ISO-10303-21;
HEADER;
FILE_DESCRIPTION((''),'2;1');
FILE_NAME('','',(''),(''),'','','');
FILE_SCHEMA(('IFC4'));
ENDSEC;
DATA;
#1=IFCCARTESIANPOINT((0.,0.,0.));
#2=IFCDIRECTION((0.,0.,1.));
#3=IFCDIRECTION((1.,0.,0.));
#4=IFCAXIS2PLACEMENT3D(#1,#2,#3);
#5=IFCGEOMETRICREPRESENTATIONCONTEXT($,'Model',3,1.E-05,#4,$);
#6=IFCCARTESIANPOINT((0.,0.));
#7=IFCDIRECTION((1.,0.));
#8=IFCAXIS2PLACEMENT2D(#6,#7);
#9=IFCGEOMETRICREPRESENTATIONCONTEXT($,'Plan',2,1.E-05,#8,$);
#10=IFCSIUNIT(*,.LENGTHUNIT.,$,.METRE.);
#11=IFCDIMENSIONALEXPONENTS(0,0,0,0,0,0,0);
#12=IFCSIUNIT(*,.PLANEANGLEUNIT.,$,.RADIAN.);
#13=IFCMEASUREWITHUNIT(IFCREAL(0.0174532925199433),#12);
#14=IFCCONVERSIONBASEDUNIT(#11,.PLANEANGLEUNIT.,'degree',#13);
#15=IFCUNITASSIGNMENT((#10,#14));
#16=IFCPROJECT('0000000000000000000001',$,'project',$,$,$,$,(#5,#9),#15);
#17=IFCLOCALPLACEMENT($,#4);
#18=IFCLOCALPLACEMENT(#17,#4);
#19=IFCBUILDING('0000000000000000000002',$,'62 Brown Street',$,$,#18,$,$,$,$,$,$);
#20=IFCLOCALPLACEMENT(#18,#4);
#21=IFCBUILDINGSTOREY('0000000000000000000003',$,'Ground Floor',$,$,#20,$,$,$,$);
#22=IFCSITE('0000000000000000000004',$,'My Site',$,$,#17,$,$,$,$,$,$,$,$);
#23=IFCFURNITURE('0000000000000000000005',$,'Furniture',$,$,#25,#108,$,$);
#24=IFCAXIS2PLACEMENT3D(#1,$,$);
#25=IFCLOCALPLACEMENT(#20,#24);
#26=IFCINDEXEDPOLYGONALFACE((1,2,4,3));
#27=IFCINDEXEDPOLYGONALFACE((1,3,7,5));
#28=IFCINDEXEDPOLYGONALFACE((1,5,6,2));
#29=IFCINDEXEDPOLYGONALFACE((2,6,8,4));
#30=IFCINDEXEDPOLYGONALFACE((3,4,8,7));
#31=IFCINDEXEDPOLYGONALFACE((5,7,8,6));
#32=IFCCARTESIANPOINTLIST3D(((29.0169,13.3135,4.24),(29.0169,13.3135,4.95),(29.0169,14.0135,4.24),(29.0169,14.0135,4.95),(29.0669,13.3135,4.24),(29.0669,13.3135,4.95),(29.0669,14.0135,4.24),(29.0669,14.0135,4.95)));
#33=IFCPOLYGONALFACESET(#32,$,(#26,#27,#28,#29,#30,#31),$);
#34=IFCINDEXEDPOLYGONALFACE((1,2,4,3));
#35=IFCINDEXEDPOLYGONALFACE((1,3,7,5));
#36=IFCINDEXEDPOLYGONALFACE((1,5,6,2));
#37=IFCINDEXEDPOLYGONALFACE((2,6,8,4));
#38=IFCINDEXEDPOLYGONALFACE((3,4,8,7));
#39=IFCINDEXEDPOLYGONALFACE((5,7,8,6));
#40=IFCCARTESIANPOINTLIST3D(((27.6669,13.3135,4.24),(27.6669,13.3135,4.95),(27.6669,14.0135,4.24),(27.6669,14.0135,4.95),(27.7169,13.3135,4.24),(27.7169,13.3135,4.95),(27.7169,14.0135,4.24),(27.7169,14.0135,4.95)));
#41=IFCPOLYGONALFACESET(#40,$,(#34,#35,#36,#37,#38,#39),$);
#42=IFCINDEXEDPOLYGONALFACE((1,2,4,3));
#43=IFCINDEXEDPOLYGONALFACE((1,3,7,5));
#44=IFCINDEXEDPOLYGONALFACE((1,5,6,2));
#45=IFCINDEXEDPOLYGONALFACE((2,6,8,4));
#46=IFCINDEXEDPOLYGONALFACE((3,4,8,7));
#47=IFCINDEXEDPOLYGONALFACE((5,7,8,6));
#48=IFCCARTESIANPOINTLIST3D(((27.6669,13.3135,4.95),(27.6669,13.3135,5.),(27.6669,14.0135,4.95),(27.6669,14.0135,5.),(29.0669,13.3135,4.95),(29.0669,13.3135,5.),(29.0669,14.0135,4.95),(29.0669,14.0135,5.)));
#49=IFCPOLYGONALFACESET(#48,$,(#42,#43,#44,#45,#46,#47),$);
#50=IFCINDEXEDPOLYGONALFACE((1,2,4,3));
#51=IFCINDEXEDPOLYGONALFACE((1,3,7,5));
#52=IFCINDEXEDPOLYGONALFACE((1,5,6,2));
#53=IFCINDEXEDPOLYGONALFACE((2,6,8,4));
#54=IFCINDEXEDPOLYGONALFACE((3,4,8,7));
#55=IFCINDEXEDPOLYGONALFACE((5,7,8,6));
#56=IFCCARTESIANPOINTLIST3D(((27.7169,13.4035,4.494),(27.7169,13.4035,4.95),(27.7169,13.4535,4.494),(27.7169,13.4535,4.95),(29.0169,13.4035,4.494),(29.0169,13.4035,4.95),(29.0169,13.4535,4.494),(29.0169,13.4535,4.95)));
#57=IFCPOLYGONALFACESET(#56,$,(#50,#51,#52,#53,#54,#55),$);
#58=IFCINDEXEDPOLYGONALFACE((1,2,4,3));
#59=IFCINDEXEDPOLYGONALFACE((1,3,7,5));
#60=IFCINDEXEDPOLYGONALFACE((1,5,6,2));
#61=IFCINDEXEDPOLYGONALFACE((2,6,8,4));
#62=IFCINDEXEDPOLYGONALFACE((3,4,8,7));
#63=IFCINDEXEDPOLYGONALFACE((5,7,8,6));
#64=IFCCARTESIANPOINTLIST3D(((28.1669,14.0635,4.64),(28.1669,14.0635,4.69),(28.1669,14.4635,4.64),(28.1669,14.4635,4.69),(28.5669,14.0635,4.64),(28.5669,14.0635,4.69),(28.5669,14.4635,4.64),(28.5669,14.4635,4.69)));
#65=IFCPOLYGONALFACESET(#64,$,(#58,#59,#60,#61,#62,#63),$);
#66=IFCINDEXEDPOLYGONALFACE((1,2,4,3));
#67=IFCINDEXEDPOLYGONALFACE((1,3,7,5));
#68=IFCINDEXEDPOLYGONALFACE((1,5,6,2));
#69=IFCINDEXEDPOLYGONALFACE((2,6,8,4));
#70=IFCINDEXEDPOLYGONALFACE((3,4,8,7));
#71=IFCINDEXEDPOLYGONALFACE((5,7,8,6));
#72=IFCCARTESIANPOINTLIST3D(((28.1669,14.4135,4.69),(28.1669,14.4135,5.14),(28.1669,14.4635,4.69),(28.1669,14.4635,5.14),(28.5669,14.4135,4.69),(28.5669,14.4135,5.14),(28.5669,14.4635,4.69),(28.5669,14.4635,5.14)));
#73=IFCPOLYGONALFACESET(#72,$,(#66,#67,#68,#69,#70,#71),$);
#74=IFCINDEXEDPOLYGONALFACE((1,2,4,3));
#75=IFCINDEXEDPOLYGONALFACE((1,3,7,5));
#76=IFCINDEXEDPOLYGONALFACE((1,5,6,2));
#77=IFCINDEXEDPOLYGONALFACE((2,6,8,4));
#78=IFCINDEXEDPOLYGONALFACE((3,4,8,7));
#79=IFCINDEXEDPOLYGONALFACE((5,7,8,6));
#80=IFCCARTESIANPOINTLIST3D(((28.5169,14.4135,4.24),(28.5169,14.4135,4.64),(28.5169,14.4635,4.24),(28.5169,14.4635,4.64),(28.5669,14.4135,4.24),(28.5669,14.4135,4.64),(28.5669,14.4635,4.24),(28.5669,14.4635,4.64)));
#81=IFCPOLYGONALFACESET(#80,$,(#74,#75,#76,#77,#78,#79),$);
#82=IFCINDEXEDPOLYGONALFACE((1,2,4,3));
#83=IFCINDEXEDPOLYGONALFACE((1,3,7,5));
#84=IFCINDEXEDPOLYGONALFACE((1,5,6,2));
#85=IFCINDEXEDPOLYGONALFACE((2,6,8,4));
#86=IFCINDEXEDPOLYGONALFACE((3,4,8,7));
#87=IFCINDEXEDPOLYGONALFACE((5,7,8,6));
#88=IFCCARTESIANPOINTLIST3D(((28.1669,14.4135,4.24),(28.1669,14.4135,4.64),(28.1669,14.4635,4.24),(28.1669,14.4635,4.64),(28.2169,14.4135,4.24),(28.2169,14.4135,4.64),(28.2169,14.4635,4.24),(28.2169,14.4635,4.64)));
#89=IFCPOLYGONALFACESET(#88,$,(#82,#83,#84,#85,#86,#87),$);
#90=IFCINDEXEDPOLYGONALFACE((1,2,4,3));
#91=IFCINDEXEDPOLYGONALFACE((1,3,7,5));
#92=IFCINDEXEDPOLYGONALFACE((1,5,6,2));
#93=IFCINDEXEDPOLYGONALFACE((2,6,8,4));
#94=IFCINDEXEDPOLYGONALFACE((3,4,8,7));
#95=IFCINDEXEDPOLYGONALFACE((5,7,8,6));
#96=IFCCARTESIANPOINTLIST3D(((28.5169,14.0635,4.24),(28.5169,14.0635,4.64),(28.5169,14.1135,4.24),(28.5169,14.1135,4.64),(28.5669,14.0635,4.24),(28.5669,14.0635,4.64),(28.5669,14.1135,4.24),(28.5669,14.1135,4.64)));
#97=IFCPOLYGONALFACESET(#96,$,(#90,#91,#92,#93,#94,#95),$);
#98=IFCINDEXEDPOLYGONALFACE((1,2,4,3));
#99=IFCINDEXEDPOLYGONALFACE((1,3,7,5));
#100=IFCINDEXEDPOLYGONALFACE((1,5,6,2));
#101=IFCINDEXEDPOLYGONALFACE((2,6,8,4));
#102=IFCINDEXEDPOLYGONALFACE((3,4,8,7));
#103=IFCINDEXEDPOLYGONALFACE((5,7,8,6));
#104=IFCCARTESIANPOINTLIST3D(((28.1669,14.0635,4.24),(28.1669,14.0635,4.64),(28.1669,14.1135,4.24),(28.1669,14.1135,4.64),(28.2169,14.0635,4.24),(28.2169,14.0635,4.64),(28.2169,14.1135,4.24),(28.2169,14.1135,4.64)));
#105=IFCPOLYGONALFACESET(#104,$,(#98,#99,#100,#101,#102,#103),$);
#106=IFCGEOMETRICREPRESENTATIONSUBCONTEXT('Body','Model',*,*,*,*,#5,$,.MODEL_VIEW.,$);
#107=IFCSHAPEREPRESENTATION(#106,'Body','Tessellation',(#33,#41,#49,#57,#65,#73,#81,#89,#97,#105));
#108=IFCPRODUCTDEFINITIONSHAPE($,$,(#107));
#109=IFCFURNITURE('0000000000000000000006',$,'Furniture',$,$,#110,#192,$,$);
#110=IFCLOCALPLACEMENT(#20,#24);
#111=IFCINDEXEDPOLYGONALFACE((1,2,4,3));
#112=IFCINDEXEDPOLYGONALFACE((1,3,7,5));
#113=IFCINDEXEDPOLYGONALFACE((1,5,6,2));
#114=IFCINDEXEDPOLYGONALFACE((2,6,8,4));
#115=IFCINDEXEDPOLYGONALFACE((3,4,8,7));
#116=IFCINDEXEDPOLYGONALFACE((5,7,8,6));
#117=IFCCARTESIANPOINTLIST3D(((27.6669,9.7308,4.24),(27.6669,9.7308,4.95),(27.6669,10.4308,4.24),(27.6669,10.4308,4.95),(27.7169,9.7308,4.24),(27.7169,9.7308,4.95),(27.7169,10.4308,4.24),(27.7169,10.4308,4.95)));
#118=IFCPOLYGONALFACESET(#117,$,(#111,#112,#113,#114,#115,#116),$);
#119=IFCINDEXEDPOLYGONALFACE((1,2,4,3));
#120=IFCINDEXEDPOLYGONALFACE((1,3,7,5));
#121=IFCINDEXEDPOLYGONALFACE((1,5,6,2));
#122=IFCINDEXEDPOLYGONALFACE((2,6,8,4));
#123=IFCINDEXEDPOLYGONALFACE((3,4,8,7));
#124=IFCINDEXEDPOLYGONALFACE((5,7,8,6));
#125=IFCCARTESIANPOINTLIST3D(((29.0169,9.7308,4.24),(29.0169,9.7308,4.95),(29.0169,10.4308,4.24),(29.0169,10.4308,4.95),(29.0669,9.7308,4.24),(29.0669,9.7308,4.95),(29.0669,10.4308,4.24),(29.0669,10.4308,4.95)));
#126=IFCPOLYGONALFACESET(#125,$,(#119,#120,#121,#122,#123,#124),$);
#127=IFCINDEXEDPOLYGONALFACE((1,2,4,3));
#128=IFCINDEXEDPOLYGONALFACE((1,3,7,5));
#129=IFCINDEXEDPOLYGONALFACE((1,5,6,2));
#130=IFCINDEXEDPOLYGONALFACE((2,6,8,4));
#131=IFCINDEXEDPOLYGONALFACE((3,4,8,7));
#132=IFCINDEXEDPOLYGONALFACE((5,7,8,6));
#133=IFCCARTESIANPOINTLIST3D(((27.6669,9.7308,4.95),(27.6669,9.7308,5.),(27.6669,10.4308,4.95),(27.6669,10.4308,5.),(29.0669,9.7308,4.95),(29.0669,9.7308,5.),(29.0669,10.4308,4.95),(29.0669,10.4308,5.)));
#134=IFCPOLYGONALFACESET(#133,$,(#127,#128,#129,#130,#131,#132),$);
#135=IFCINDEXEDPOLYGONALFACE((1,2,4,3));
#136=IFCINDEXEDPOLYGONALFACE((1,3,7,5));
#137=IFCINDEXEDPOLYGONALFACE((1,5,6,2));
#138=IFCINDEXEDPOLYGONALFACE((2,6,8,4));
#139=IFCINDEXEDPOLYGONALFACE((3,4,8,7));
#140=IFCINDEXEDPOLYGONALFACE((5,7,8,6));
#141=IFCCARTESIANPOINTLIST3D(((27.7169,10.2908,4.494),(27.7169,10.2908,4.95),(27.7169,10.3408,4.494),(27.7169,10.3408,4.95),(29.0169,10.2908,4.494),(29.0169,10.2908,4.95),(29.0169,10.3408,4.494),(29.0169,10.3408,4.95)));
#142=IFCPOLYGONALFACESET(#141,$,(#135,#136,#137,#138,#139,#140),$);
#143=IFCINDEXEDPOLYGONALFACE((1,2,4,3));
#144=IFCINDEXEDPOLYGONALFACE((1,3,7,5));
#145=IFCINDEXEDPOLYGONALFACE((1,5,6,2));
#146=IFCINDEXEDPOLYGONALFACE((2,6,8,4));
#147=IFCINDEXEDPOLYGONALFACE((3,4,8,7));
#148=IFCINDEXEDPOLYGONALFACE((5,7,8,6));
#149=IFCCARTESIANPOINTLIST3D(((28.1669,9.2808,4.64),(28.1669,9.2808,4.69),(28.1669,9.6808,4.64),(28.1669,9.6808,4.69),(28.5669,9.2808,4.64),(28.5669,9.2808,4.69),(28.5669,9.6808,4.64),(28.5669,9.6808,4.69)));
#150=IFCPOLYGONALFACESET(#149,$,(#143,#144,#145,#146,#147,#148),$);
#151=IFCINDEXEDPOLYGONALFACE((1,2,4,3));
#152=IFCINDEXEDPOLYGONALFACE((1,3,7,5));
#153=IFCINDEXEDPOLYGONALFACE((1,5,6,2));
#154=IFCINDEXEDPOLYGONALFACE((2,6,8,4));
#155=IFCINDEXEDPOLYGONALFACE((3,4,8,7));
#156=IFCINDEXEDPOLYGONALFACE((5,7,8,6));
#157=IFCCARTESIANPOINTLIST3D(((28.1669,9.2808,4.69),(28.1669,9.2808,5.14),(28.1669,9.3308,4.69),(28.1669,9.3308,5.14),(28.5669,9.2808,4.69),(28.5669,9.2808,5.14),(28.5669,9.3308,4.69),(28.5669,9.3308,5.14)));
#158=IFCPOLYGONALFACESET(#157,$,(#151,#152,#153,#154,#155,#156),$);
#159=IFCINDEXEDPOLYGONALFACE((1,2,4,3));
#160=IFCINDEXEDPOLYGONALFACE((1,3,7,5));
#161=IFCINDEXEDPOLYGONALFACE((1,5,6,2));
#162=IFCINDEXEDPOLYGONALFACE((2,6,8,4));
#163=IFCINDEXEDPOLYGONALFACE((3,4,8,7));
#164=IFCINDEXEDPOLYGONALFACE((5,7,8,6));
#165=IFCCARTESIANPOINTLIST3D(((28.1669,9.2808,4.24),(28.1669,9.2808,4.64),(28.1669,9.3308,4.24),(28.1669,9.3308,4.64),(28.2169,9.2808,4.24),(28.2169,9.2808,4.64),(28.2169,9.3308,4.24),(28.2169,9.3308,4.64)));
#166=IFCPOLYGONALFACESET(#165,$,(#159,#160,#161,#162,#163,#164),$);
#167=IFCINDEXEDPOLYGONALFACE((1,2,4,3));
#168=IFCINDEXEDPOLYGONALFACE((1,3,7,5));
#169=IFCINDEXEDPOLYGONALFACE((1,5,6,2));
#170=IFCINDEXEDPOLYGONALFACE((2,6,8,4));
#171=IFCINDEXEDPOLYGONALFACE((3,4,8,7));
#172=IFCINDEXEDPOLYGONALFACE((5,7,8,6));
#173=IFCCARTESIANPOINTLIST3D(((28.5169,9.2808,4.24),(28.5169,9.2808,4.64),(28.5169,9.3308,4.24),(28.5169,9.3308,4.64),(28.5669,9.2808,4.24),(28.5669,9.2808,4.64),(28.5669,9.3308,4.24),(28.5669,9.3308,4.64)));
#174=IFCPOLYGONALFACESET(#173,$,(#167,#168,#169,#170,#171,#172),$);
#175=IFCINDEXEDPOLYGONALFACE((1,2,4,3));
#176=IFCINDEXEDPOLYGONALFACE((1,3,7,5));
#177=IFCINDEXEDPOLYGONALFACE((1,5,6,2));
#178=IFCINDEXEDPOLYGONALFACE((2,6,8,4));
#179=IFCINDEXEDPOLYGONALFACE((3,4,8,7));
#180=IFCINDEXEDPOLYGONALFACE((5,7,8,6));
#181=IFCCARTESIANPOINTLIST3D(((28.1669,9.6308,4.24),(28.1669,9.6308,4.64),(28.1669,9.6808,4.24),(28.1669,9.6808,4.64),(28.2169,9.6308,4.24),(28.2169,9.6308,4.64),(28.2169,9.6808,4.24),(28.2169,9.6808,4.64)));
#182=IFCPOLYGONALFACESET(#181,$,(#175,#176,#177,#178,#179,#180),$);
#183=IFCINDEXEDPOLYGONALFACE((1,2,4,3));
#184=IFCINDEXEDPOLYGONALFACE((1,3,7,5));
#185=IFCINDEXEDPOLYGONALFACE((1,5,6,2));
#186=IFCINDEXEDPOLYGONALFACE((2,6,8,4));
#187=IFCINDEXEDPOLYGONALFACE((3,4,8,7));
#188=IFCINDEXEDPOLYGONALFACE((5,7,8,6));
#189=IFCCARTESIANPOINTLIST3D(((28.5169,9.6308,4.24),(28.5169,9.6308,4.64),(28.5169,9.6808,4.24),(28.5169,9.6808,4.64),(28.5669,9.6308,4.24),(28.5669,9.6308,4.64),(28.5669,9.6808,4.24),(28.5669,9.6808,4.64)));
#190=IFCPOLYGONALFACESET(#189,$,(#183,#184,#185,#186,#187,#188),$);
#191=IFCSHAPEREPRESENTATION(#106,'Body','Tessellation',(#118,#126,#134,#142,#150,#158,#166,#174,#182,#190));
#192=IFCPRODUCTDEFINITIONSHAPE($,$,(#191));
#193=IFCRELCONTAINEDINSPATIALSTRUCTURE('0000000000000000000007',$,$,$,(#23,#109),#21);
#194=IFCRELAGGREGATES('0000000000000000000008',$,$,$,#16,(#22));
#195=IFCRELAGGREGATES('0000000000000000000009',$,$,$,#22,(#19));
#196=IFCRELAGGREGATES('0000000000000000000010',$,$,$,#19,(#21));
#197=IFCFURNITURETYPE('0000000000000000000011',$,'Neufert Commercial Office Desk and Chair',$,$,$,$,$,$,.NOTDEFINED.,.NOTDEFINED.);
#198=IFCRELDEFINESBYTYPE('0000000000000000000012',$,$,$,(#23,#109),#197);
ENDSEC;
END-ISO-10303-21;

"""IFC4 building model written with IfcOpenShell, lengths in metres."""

from ifc_helpers import new_model, entity, si_unit, converted_unit, frame, origin_with_axes, origin_2d_with_axis, place, context, subcontext, project, spatial, line, indexed_curve, outline, extrude, shape, source, transform, mapped, type_object, type_shapes, element, save


model = new_model("IFC4")

# Units and contexts
model_context = context("Model", 3, precision=1e-05, world=origin_with_axes())
plan_context = context("Plan", 2, precision=1e-05, world=origin_2d_with_axis())
body_context_1 = subcontext(model_context, "Body", "Model", "MODEL_VIEW")
body_context_2 = subcontext(plan_context, "Body", "Plan", "PLAN_VIEW")
ifc_project = project(units=[si_unit("LENGTHUNIT", "METRE"), converted_unit("PLANEANGLEUNIT", "degree", entity("IfcReal", 0.0174532925199433), si_unit("PLANEANGLEUNIT", "RADIAN"), dimensions=[0, 0, 0, 0, 0, 0, 0])], contexts=[model_context, plan_context])

# Site, building, storey
site_placement = place(None, origin_with_axes())
site = spatial("IfcSite", under=ifc_project, at=site_placement, Name="My Site")
building_placement = place(site_placement, origin_with_axes())
building = spatial("IfcBuilding", under=site, at=building_placement, Name="62 Brown Street")
storey_placement = place(building_placement, origin_with_axes())
storey = spatial("IfcBuildingStorey", under=building, at=storey_placement, Name="Ground Floor")

# Furniture
furniture_type_1 = type_object("IfcFurnitureType", Name="Neufert Commercial Office Desk and Chair", AssemblyPlace="NOTDEFINED", PredefinedType="NOTDEFINED")
shared_shape_1 = source(origin_with_axes(), body_context_1, "Body", "SweptSolid", [
    extrude(outline(indexed_curve([(0.0, 0.0), (0.05, 0.0), (0.05, 0.7), (0.0, 0.7)], segments=[line(1, 2, 3, 4, 1)])), frame((0.0, 0.45, 0.0), z_axis=(0.0, 0.0, 1.0), x_axis=(1.0, 0.0, 0.0)), (0.0, 0.0, 1.0), 0.71),
    extrude(outline(indexed_curve([(0.0, 0.0), (0.05, 0.0), (0.05, 0.7), (0.0, 0.7)], segments=[line(1, 2, 3, 4, 1)])), frame((1.35, 0.45, 0.0), z_axis=(0.0, 0.0, 1.0), x_axis=(1.0, 0.0, 0.0)), (0.0, 0.0, 1.0), 0.71),
    extrude(outline(indexed_curve([(0.0, 0.0), (1.4, 0.0), (1.4, 0.7), (0.0, 0.7)], segments=[line(1, 2, 3, 4, 1)])), frame((0.0, 0.45, 0.71), z_axis=(0.0, 0.0, 1.0), x_axis=(1.0, 0.0, 0.0)), (0.0, 0.0, 1.0), 0.05),
    extrude(outline(indexed_curve([(0.05, 0.56), (1.35, 0.56), (1.35, 0.61), (0.05, 0.61)], segments=[line(1, 2, 3, 4, 1)])), frame((0.0, 0.45, 0.254), z_axis=(0.0, 0.0, 1.0), x_axis=(1.0, 0.0, 0.0)), (0.0, 0.0, 1.0), 0.456),
    extrude(outline(indexed_curve([(-0.2, 0.0), (0.2, 0.0), (0.2, 0.4), (-0.2, 0.4)], segments=[line(1, 2, 3, 4, 1)])), frame((0.7, 0.0, 0.45), z_axis=(0.0, 0.0, 1.0), x_axis=(1.0, 0.0, 0.0)), (0.0, 0.0, -1.0), 0.05),
    extrude(outline(indexed_curve([(-0.2, 0.0), (0.2, 0.0), (0.2, 0.05), (-0.2, 0.05)], segments=[line(1, 2, 3, 4, 1)])), frame((0.7, 0.0, 0.9), z_axis=(0.0, 0.0, 1.0), x_axis=(1.0, 0.0, 0.0)), (0.0, 0.0, -1.0), 0.45),
    extrude(outline(indexed_curve([(-0.2, 0.0), (-0.15, 0.0), (-0.15, 0.05), (-0.2, 0.05)], segments=[line(1, 2, 3, 4, 1)])), frame((0.7, 0.0, 0.0), z_axis=(0.0, 0.0, 1.0), x_axis=(1.0, 0.0, 0.0)), (0.0, 0.0, 1.0), 0.4),
    extrude(outline(indexed_curve([(0.2, 0.0), (0.15, 0.0), (0.15, 0.05), (0.2, 0.05)], segments=[line(1, 2, 3, 4, 1)])), frame((0.7, 0.0, 0.0), z_axis=(0.0, 0.0, 1.0), x_axis=(1.0, 0.0, 0.0)), (0.0, 0.0, 1.0), 0.4),
    extrude(outline(indexed_curve([(-0.2, 0.4), (-0.15, 0.4), (-0.15, 0.35), (-0.2, 0.35)], segments=[line(1, 2, 3, 4, 1)])), frame((0.7, 0.0, 0.0), z_axis=(0.0, 0.0, 1.0), x_axis=(1.0, 0.0, 0.0)), (0.0, 0.0, 1.0), 0.4),
    extrude(outline(indexed_curve([(0.2, 0.4), (0.15, 0.4), (0.15, 0.35), (0.2, 0.35)], segments=[line(1, 2, 3, 4, 1)])), frame((0.7, 0.0, 0.0), z_axis=(0.0, 0.0, 1.0), x_axis=(1.0, 0.0, 0.0)), (0.0, 0.0, 1.0), 0.4),
])
shared_shape_2 = source(origin_with_axes(), body_context_2, "Body", "Curve2D", [
    entity("IfcIndexedPolyCurve", entity("IfcCartesianPointList2D", [[0.0, 0.45], [1.4, 0.45], [1.4, 1.15], [0.0, 1.15]]), [entity("IfcLineIndex", [1, 2, 3, 4, 1])]),
    entity("IfcIndexedPolyCurve", entity("IfcCartesianPointList2D", [[0.5, 0.4], [0.9, 0.4]])),
    entity("IfcIndexedPolyCurve", entity("IfcCartesianPointList2D", [[0.5, 0.4], [0.5, 0.2], [0.5586, 0.0586], [0.7, 0.0], [0.8414, 0.0586], [0.9, 0.2], [0.9, 0.4]]), [entity("IfcLineIndex", [1, 2]), entity("IfcArcIndex", [2, 3, 4]), entity("IfcArcIndex", [4, 5, 6]), entity("IfcLineIndex", [6, 7])]),
    entity("IfcIndexedPolyCurve", entity("IfcCartesianPointList2D", [[0.54, 0.4], [0.54, 0.2], [0.5869, 0.0869], [0.7, 0.04], [0.8131, 0.0869], [0.86, 0.2], [0.86, 0.4]]), [entity("IfcLineIndex", [1, 2]), entity("IfcArcIndex", [2, 3, 4]), entity("IfcArcIndex", [4, 5, 6]), entity("IfcLineIndex", [6, 7])]),
])
type_shapes(furniture_type_1, [shared_shape_1, shared_shape_2])
for number, where, z_axis, x_axis, name in (
    (1, (29.0669, 14.4635, 4.24), (0.0, 0.0, 1.0), (-1.0, 0.0, 0.0), "Furniture"),
    (2, (27.6669, 9.2808, 4.24), (0.0, 0.0, 1.0), (1.0, 0.0, 0.0), "Furniture"),
):
    element("IfcFurniture", number, at=place(storey_placement, frame(where, z_axis=z_axis, x_axis=x_axis)), inside=storey, type_object=furniture_type_1, Name=name, shapes=[
        shape(body_context_1, "Body", "MappedRepresentation", [mapped(shared_shape_1, transform((0.0, 0.0, 0.0), x_axis=(1.0, 0.0, 0.0), y_axis=(0.0, 1.0, 0.0), z_axis=(0.0, 0.0, 1.0), scale=1.0))]),
        shape(body_context_2, "Body", "MappedRepresentation", [mapped(shared_shape_2, transform((0.0, 0.0, 0.0), x_axis=(1.0, 0.0, 0.0), y_axis=(0.0, 1.0, 0.0), z_axis=(0.0, 0.0, 1.0), scale=1.0))]),
    ])

save(model, "model.ifc")
